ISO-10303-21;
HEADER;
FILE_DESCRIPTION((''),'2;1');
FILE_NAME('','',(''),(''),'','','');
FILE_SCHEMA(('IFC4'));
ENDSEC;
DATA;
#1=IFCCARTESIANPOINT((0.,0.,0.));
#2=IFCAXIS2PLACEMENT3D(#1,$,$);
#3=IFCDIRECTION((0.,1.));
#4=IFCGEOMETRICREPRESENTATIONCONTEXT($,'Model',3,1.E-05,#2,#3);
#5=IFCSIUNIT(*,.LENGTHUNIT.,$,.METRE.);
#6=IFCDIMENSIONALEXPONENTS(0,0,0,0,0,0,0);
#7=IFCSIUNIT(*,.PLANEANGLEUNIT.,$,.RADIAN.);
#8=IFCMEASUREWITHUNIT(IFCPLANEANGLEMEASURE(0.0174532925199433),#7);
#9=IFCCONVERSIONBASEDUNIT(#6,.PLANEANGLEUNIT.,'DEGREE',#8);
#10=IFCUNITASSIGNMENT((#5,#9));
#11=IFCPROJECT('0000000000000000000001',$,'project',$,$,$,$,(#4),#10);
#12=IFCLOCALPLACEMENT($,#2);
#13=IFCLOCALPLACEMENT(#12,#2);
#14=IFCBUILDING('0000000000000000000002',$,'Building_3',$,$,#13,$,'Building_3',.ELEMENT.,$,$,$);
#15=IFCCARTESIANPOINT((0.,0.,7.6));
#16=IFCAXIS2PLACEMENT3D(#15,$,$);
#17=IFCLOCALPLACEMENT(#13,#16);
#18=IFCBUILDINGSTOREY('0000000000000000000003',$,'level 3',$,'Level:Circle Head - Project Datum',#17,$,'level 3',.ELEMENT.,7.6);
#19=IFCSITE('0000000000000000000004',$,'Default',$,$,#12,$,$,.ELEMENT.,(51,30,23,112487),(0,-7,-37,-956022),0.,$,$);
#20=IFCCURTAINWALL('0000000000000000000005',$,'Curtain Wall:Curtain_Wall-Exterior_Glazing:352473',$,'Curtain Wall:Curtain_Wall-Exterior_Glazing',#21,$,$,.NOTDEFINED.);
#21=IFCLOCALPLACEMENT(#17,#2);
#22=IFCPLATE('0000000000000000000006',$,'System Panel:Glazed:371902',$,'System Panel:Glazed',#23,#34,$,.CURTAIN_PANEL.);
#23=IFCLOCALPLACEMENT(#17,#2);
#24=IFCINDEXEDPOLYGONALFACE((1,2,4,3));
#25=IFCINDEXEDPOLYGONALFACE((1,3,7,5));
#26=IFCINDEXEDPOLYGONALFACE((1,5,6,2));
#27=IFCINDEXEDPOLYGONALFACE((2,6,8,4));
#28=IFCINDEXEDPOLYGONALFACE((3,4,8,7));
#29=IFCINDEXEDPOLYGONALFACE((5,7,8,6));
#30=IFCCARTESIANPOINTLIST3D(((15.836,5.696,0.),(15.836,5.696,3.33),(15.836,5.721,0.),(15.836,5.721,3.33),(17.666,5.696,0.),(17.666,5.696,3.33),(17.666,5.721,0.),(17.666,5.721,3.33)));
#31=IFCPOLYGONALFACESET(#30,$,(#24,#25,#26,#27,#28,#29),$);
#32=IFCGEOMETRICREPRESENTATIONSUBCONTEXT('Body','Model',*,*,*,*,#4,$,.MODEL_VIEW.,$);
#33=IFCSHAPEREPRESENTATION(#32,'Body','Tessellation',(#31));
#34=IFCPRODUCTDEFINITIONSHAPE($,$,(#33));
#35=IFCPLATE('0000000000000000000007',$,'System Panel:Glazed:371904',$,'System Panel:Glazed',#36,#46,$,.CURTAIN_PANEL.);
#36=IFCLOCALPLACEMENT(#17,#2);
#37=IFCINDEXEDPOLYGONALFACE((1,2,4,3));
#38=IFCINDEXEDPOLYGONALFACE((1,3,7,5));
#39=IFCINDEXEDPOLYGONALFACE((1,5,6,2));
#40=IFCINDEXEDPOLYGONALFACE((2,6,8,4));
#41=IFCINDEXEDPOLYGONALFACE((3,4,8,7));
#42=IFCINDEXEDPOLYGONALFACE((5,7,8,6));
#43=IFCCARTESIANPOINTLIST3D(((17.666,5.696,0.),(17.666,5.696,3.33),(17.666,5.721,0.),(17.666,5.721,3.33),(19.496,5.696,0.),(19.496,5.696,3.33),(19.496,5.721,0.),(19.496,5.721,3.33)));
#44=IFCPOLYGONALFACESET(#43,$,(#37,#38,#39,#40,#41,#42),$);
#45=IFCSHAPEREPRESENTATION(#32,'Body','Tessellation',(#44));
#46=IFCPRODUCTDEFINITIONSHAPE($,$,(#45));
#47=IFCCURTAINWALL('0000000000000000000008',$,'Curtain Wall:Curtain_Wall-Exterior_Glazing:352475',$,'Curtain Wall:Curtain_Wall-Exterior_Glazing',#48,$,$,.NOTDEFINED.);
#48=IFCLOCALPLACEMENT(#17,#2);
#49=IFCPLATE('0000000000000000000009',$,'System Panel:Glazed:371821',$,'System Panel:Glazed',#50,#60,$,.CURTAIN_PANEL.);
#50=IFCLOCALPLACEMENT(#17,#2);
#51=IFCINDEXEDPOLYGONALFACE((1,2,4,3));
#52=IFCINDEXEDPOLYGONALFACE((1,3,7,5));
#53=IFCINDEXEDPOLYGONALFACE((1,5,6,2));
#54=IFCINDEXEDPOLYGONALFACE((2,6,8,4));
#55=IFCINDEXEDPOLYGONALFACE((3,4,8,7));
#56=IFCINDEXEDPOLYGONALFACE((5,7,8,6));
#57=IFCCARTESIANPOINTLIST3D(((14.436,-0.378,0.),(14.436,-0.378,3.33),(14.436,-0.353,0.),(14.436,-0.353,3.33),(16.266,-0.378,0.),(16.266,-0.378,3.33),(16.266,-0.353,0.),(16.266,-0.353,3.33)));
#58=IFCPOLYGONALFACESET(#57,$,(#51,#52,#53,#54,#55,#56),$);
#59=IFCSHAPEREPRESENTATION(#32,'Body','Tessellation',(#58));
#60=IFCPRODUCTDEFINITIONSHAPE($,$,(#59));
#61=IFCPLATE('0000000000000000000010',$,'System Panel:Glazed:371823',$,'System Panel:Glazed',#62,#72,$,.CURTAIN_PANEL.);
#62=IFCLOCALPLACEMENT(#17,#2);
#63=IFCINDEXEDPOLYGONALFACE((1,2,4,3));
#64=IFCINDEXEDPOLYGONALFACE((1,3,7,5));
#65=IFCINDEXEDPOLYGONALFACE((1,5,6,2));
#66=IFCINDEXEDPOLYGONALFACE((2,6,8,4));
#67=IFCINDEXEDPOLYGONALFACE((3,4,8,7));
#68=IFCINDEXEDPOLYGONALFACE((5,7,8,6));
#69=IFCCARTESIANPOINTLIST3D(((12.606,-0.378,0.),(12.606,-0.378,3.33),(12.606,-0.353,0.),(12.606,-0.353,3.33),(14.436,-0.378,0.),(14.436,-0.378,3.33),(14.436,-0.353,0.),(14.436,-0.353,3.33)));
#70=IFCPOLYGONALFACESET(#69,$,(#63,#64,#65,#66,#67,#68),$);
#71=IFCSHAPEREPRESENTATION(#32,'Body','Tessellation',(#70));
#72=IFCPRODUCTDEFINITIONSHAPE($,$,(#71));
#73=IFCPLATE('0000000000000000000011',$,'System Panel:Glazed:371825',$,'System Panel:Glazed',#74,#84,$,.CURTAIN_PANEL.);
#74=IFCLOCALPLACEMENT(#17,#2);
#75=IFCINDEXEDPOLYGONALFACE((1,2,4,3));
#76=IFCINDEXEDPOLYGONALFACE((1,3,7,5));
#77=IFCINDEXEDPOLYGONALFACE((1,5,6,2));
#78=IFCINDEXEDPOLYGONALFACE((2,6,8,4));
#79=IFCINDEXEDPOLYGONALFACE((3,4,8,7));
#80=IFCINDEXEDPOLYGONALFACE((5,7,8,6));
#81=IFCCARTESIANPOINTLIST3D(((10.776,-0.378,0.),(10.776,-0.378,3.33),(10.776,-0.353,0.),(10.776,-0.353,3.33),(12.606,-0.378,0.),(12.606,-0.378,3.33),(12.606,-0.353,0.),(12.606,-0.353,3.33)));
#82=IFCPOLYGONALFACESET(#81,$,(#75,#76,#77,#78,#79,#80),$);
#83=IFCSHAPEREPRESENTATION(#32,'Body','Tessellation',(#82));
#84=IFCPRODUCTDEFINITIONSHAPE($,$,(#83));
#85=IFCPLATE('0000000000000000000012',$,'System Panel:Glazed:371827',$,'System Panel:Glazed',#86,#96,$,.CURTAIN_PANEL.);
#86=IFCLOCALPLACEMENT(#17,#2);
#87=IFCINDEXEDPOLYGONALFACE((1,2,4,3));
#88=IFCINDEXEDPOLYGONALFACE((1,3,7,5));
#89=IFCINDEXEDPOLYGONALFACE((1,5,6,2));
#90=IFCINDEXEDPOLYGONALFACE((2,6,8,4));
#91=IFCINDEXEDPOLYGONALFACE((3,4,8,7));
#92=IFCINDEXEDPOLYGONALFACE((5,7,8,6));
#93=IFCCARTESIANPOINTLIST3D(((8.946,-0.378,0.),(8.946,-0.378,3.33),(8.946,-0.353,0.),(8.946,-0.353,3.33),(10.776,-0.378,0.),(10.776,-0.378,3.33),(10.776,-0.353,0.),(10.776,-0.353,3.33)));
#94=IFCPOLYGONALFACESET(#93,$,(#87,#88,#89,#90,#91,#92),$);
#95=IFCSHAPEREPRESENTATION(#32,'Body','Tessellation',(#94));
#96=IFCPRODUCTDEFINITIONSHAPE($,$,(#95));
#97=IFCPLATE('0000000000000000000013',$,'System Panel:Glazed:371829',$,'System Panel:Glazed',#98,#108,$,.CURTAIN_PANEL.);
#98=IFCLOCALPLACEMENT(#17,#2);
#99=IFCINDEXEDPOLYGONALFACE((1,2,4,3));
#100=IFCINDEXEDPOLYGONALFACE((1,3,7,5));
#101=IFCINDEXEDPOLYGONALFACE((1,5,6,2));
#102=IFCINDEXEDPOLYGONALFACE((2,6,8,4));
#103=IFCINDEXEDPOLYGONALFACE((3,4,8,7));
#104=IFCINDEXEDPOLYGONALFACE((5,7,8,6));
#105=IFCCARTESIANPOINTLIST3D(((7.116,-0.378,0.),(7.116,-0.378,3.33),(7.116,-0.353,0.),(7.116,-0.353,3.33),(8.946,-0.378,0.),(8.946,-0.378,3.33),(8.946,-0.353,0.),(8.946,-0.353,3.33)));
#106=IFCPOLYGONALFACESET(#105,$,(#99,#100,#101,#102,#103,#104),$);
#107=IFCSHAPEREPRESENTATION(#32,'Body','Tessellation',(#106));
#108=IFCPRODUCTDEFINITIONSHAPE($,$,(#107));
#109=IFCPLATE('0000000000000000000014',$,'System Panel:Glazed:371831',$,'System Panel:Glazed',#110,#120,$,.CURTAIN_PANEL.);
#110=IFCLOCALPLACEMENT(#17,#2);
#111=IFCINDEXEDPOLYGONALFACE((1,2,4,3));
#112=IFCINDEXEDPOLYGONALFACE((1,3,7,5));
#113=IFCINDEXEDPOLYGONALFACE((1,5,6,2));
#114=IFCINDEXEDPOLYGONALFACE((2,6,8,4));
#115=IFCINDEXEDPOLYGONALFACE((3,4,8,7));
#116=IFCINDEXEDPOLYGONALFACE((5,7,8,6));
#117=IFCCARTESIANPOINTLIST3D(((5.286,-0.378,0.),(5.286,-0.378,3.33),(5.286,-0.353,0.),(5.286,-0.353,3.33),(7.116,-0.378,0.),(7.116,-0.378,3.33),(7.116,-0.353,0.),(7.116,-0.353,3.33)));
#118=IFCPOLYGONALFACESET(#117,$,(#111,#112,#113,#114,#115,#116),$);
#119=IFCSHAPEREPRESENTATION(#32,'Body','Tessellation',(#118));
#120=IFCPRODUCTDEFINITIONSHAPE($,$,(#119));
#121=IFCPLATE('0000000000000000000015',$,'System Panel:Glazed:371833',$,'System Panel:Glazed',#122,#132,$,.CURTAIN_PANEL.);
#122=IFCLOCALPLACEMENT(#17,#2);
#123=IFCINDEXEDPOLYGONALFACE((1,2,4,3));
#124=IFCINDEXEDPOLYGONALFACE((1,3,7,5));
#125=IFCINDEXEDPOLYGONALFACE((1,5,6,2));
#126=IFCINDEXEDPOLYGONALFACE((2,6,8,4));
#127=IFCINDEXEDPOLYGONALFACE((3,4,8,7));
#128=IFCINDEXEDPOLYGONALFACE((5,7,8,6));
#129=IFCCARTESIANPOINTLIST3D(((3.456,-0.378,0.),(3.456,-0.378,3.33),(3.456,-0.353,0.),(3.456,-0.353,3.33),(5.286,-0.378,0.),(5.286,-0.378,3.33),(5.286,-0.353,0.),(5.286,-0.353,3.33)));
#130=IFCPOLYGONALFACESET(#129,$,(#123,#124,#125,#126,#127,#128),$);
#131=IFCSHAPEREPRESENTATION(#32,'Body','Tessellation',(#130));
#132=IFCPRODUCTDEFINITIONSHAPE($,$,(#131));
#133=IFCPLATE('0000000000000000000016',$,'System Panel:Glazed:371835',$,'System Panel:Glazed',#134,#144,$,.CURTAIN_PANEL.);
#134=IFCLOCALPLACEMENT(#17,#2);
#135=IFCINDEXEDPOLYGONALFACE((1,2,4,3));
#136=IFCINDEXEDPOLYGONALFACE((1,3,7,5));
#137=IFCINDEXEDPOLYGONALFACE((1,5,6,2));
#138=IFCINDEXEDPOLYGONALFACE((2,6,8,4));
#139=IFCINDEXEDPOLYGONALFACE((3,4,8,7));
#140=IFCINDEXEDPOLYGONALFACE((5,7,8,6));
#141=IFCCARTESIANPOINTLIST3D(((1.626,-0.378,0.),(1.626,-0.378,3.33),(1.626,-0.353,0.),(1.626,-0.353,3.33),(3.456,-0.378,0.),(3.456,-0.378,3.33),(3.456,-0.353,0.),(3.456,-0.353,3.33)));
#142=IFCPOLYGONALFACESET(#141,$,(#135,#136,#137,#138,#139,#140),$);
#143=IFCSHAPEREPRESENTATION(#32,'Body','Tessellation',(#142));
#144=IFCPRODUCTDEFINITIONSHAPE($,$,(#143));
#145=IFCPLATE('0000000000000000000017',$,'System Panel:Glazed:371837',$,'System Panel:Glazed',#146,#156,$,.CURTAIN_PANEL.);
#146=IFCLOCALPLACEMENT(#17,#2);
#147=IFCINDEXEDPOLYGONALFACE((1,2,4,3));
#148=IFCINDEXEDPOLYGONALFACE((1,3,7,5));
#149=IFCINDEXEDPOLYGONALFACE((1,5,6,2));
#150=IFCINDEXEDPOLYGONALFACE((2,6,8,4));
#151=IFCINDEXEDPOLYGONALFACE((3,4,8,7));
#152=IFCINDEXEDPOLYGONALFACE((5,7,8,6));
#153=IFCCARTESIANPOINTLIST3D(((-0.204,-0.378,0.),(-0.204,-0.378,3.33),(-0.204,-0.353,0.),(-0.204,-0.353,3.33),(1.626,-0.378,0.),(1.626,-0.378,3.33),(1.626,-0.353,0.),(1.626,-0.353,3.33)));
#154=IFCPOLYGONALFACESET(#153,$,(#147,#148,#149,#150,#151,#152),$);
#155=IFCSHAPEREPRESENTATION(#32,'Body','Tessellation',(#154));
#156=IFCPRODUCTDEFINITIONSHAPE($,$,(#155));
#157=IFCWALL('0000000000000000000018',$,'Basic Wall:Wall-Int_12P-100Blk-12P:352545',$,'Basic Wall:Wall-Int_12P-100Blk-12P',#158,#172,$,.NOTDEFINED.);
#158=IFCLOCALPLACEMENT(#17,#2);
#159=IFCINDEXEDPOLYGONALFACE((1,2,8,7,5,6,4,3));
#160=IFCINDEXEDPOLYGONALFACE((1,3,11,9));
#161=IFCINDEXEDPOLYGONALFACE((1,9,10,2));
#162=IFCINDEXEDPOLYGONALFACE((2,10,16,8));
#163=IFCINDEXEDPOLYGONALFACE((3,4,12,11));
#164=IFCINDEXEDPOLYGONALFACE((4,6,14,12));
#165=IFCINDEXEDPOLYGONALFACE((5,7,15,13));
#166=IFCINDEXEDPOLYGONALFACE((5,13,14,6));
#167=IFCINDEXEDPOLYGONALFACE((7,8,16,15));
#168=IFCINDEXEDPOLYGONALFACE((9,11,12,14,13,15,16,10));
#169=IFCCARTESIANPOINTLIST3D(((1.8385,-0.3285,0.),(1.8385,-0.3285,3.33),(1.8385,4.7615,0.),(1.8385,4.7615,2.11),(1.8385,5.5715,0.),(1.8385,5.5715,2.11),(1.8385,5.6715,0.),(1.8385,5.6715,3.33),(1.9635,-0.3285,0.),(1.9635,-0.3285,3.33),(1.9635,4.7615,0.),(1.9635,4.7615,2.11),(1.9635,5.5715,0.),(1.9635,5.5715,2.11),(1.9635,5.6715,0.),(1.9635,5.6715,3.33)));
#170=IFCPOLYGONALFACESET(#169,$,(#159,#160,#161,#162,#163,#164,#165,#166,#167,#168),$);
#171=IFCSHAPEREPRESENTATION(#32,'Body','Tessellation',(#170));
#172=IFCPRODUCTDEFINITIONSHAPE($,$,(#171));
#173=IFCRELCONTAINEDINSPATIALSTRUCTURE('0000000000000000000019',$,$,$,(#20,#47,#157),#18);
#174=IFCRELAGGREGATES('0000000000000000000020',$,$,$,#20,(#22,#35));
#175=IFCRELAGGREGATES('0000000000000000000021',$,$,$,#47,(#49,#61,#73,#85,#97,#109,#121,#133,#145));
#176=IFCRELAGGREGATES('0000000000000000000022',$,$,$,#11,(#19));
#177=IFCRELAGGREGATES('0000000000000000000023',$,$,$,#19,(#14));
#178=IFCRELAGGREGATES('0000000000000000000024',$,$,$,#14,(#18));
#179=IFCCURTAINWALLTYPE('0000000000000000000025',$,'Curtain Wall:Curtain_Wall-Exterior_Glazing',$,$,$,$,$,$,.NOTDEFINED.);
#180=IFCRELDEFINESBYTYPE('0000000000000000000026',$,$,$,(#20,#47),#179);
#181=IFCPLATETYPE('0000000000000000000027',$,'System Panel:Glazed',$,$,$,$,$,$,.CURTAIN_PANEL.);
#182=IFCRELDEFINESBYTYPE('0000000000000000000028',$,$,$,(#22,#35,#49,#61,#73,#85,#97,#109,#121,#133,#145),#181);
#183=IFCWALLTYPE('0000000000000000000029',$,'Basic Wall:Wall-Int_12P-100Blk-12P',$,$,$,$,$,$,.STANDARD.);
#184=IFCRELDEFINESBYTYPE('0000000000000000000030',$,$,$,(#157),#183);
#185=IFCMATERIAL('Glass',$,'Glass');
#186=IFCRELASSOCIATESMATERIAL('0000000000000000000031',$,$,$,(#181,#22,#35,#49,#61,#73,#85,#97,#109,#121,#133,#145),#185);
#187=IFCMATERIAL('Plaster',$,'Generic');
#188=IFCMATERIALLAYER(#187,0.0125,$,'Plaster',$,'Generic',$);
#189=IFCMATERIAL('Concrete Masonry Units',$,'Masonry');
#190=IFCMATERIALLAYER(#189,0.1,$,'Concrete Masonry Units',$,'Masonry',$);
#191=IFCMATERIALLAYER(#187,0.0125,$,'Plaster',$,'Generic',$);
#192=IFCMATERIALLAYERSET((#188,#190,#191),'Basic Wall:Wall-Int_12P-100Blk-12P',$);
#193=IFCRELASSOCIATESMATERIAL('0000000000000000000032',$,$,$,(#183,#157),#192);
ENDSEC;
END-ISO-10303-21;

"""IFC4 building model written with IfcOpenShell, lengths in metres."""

from ifc_helpers import new_model, entity, si_unit, converted_unit, direction, frame, frame_2d, origin, origin_2d_with_axis, place, context, subcontext, project, spatial, polyline, rectangle, extrude, clip, bounded_halfspace, source, transform, mapped, material, layer, layer_set, layer_usage, type_object, type_shapes, element, aggregate, save


model = new_model("IFC4")

# Units and contexts
model_context = context("Model", 3, precision=1e-05, world=origin(), true_north=direction((0.0, 1.0)))
body_context = subcontext(model_context, "Body", "Model", "MODEL_VIEW")
ifc_project = project(units=[si_unit("LENGTHUNIT", "METRE"), converted_unit("PLANEANGLEUNIT", "DEGREE", entity("IfcPlaneAngleMeasure", 0.0174532925199433), si_unit("PLANEANGLEUNIT", "RADIAN"), dimensions=[0, 0, 0, 0, 0, 0, 0])], contexts=[model_context])

# Site, building, storey
site_placement = place(None, origin())
site = spatial("IfcSite", under=ifc_project, at=site_placement, Name="Default", CompositionType="ELEMENT", RefLatitude=(51, 30, 23, 112487), RefLongitude=(0, -7, -37, -956022), RefElevation=0.0)
building_placement = place(site_placement, origin())
building = spatial("IfcBuilding", under=site, at=building_placement, Name="Building_3", LongName="Building_3", CompositionType="ELEMENT")
storey_placement = place(building_placement, frame((0.0, 0.0, 7.6)))
storey = spatial("IfcBuildingStorey", under=building, at=storey_placement, Name="level 3", ObjectType="Level:Circle Head - Project Datum", LongName="level 3", CompositionType="ELEMENT", Elevation=7.6)

# Curtain walls, plates
curtain_wall_type = type_object("IfcCurtainWallType", Name="Curtain Wall:Curtain_Wall-Exterior_Glazing", PredefinedType="NOTDEFINED")
curtain_wall_1_placement = place(storey_placement, frame((0.0, 0.0, -7.6)))
curtain_wall_1 = element("IfcCurtainWall", 1, at=curtain_wall_1_placement, inside=storey, type_object=curtain_wall_type, Name="Curtain Wall:Curtain_Wall-Exterior_Glazing:352473", ObjectType="Curtain Wall:Curtain_Wall-Exterior_Glazing", PredefinedType="NOTDEFINED")
ifc_material_1 = material(Name="Glass", Category="Glass")
plate_type = type_object("IfcPlateType", Name="System Panel:Glazed", PredefinedType="CURTAIN_PANEL", material=ifc_material_1)
shared_shape_1 = source(origin(), body_context, "Body", "SweptSolid", [
    extrude(rectangle(XDim=0.025, YDim=1.83, at=origin_2d_with_axis()), frame((0.915, 0.0125, 0.0), z_axis=(0.0, 0.0, 1.0), x_axis=(0.0, 1.0, 0.0)), (0.0, 0.0, 1.0), 3.33),
])
type_shapes(plate_type, [shared_shape_1])
plate_1_placement = place(curtain_wall_1_placement, frame((15.836, 5.696, 7.6)))
plate_1 = element("IfcPlate", 2, at=plate_1_placement, type_object=plate_type, material=ifc_material_1, Name="System Panel:Glazed:371902", ObjectType="System Panel:Glazed", PredefinedType="CURTAIN_PANEL", context=body_context, shape_type="MappedRepresentation", body=[
    mapped(shared_shape_1, transform((0.0, 0.0, 0.0), scale=1.0)),
])
plate_2_placement = place(curtain_wall_1_placement, frame((17.666, 5.696, 7.6)))
plate_2 = element("IfcPlate", 3, at=plate_2_placement, type_object=plate_type, material=ifc_material_1, Name="System Panel:Glazed:371904", ObjectType="System Panel:Glazed", PredefinedType="CURTAIN_PANEL", context=body_context, shape_type="MappedRepresentation", body=[
    mapped(shared_shape_1, transform((0.0, 0.0, 0.0), scale=1.0)),
])
aggregate(curtain_wall_1, [plate_1, plate_2])
curtain_wall_2_placement = place(storey_placement, frame((0.0, 0.0, -7.6)))
curtain_wall_2 = element("IfcCurtainWall", 4, at=curtain_wall_2_placement, inside=storey, type_object=curtain_wall_type, Name="Curtain Wall:Curtain_Wall-Exterior_Glazing:352475", ObjectType="Curtain Wall:Curtain_Wall-Exterior_Glazing", PredefinedType="NOTDEFINED")
plate_3_placement = place(curtain_wall_2_placement, frame((16.266, -0.353, 7.6), z_axis=(0.0, 0.0, 1.0), x_axis=(-1.0, 0.0, 0.0)))
plate_3 = element("IfcPlate", 5, at=plate_3_placement, type_object=plate_type, material=ifc_material_1, Name="System Panel:Glazed:371821", ObjectType="System Panel:Glazed", PredefinedType="CURTAIN_PANEL", context=body_context, shape_type="MappedRepresentation", body=[
    mapped(shared_shape_1, transform((0.0, 0.0, 0.0), scale=1.0)),
])
plate_4_placement = place(curtain_wall_2_placement, frame((14.436, -0.353, 7.6), z_axis=(0.0, 0.0, 1.0), x_axis=(-1.0, 0.0, 0.0)))
plate_4 = element("IfcPlate", 6, at=plate_4_placement, type_object=plate_type, material=ifc_material_1, Name="System Panel:Glazed:371823", ObjectType="System Panel:Glazed", PredefinedType="CURTAIN_PANEL", context=body_context, shape_type="MappedRepresentation", body=[
    mapped(shared_shape_1, transform((0.0, 0.0, 0.0), scale=1.0)),
])
plate_5_placement = place(curtain_wall_2_placement, frame((12.606, -0.353, 7.6), z_axis=(0.0, 0.0, 1.0), x_axis=(-1.0, 0.0, 0.0)))
plate_5 = element("IfcPlate", 7, at=plate_5_placement, type_object=plate_type, material=ifc_material_1, Name="System Panel:Glazed:371825", ObjectType="System Panel:Glazed", PredefinedType="CURTAIN_PANEL", context=body_context, shape_type="MappedRepresentation", body=[
    mapped(shared_shape_1, transform((0.0, 0.0, 0.0), scale=1.0)),
])
plate_6_placement = place(curtain_wall_2_placement, frame((10.776, -0.353, 7.6), z_axis=(0.0, 0.0, 1.0), x_axis=(-1.0, 0.0, 0.0)))
plate_6 = element("IfcPlate", 8, at=plate_6_placement, type_object=plate_type, material=ifc_material_1, Name="System Panel:Glazed:371827", ObjectType="System Panel:Glazed", PredefinedType="CURTAIN_PANEL", context=body_context, shape_type="MappedRepresentation", body=[
    mapped(shared_shape_1, transform((0.0, 0.0, 0.0), scale=1.0)),
])
plate_7_placement = place(curtain_wall_2_placement, frame((8.946, -0.353, 7.6), z_axis=(0.0, 0.0, 1.0), x_axis=(-1.0, 0.0, 0.0)))
plate_7 = element("IfcPlate", 9, at=plate_7_placement, type_object=plate_type, material=ifc_material_1, Name="System Panel:Glazed:371829", ObjectType="System Panel:Glazed", PredefinedType="CURTAIN_PANEL", context=body_context, shape_type="MappedRepresentation", body=[
    mapped(shared_shape_1, transform((0.0, 0.0, 0.0), scale=1.0)),
])
plate_8_placement = place(curtain_wall_2_placement, frame((7.116, -0.353, 7.6), z_axis=(0.0, 0.0, 1.0), x_axis=(-1.0, 0.0, 0.0)))
plate_8 = element("IfcPlate", 10, at=plate_8_placement, type_object=plate_type, material=ifc_material_1, Name="System Panel:Glazed:371831", ObjectType="System Panel:Glazed", PredefinedType="CURTAIN_PANEL", context=body_context, shape_type="MappedRepresentation", body=[
    mapped(shared_shape_1, transform((0.0, 0.0, 0.0), scale=1.0)),
])
plate_9_placement = place(curtain_wall_2_placement, frame((5.286, -0.353, 7.6), z_axis=(0.0, 0.0, 1.0), x_axis=(-1.0, 0.0, 0.0)))
plate_9 = element("IfcPlate", 11, at=plate_9_placement, type_object=plate_type, material=ifc_material_1, Name="System Panel:Glazed:371833", ObjectType="System Panel:Glazed", PredefinedType="CURTAIN_PANEL", context=body_context, shape_type="MappedRepresentation", body=[
    mapped(shared_shape_1, transform((0.0, 0.0, 0.0), scale=1.0)),
])
plate_10_placement = place(curtain_wall_2_placement, frame((3.456, -0.353, 7.6), z_axis=(0.0, 0.0, 1.0), x_axis=(-1.0, 0.0, 0.0)))
plate_10 = element("IfcPlate", 12, at=plate_10_placement, type_object=plate_type, material=ifc_material_1, Name="System Panel:Glazed:371835", ObjectType="System Panel:Glazed", PredefinedType="CURTAIN_PANEL", context=body_context, shape_type="MappedRepresentation", body=[
    mapped(shared_shape_1, transform((0.0, 0.0, 0.0), scale=1.0)),
])
plate_11_placement = place(curtain_wall_2_placement, frame((1.626, -0.353, 7.6), z_axis=(0.0, 0.0, 1.0), x_axis=(-1.0, 0.0, 0.0)))
plate_11 = element("IfcPlate", 13, at=plate_11_placement, type_object=plate_type, material=ifc_material_1, Name="System Panel:Glazed:371837", ObjectType="System Panel:Glazed", PredefinedType="CURTAIN_PANEL", context=body_context, shape_type="MappedRepresentation", body=[
    mapped(shared_shape_1, transform((0.0, 0.0, 0.0), scale=1.0)),
])
aggregate(curtain_wall_2, [plate_3, plate_4, plate_5, plate_6, plate_7, plate_8, plate_9, plate_10, plate_11])

# Wall, opening
ifc_material_2 = material(Name="Plaster", Category="Generic")
ifc_layer_1 = layer(ifc_material_2, 0.0125, Name="Plaster", Category="Generic")
ifc_material_3 = material(Name="Concrete Masonry Units", Category="Masonry")
ifc_layer_2 = layer(ifc_material_3, 0.1, Name="Concrete Masonry Units", Category="Masonry")
ifc_layer_3 = layer(ifc_material_2, 0.0125, Name="Plaster", Category="Generic")
ifc_layer_set = layer_set([ifc_layer_1, ifc_layer_2, ifc_layer_3], Name="Basic Wall:Wall-Int_12P-100Blk-12P")
ifc_layer_usage_1 = layer_usage(ifc_layer_set, "AXIS2", "NEGATIVE", 0.0625)
wall_type = type_object("IfcWallType", Name="Basic Wall:Wall-Int_12P-100Blk-12P", PredefinedType="STANDARD", material=ifc_layer_set)
wall_1_placement = place(storey_placement, frame((1.901, 5.6715, 0.0), z_axis=(0.0, 0.0, 1.0), x_axis=(0.0, -1.0, 0.0)))
wall_1 = element("IfcWall", 14, at=wall_1_placement, inside=storey, type_object=wall_type, material=ifc_layer_usage_1, Name="Basic Wall:Wall-Int_12P-100Blk-12P:352545", ObjectType="Basic Wall:Wall-Int_12P-100Blk-12P", PredefinedType="NOTDEFINED", context=body_context, shape_type="Clipping", body=[
    clip(extrude(rectangle(XDim=6.0, YDim=0.125, at=frame_2d((3.0, 0.0), x_axis=(1.0, 0.0))), origin(), (0.0, 0.0, 1.0), 3.33), bounded_halfspace(frame((0.0, -0.0625, 3.33), z_axis=(0.0, 0.0, -1.0), x_axis=(-1.0, 0.0, 0.0)), True, frame((0.0, -0.0625, 3.33)), polyline([(0.0, 0.0), (6.0, 0.0), (6.0, 0.125), (0.0, 0.125), (0.0, 0.0)]))),
])
opening_1_placement = place(wall_1_placement, frame((0.1, -0.0625, 0.0)))
element("IfcOpeningElement", 15, at=opening_1_placement, cuts=wall_1, PredefinedType="OPENING", context=body_context, shape_type="SweptSolid", body=[
    extrude(rectangle(XDim=2.11, YDim=0.81, at=frame_2d((1.055, 0.405), x_axis=(1.0, 0.0))), frame((0.0, 0.0, 0.0), z_axis=(0.0, 1.0, 0.0), x_axis=(0.0, 0.0, 1.0)), (0.0, 0.0, 1.0), 0.125),
])

save(model, "model.ifc")
